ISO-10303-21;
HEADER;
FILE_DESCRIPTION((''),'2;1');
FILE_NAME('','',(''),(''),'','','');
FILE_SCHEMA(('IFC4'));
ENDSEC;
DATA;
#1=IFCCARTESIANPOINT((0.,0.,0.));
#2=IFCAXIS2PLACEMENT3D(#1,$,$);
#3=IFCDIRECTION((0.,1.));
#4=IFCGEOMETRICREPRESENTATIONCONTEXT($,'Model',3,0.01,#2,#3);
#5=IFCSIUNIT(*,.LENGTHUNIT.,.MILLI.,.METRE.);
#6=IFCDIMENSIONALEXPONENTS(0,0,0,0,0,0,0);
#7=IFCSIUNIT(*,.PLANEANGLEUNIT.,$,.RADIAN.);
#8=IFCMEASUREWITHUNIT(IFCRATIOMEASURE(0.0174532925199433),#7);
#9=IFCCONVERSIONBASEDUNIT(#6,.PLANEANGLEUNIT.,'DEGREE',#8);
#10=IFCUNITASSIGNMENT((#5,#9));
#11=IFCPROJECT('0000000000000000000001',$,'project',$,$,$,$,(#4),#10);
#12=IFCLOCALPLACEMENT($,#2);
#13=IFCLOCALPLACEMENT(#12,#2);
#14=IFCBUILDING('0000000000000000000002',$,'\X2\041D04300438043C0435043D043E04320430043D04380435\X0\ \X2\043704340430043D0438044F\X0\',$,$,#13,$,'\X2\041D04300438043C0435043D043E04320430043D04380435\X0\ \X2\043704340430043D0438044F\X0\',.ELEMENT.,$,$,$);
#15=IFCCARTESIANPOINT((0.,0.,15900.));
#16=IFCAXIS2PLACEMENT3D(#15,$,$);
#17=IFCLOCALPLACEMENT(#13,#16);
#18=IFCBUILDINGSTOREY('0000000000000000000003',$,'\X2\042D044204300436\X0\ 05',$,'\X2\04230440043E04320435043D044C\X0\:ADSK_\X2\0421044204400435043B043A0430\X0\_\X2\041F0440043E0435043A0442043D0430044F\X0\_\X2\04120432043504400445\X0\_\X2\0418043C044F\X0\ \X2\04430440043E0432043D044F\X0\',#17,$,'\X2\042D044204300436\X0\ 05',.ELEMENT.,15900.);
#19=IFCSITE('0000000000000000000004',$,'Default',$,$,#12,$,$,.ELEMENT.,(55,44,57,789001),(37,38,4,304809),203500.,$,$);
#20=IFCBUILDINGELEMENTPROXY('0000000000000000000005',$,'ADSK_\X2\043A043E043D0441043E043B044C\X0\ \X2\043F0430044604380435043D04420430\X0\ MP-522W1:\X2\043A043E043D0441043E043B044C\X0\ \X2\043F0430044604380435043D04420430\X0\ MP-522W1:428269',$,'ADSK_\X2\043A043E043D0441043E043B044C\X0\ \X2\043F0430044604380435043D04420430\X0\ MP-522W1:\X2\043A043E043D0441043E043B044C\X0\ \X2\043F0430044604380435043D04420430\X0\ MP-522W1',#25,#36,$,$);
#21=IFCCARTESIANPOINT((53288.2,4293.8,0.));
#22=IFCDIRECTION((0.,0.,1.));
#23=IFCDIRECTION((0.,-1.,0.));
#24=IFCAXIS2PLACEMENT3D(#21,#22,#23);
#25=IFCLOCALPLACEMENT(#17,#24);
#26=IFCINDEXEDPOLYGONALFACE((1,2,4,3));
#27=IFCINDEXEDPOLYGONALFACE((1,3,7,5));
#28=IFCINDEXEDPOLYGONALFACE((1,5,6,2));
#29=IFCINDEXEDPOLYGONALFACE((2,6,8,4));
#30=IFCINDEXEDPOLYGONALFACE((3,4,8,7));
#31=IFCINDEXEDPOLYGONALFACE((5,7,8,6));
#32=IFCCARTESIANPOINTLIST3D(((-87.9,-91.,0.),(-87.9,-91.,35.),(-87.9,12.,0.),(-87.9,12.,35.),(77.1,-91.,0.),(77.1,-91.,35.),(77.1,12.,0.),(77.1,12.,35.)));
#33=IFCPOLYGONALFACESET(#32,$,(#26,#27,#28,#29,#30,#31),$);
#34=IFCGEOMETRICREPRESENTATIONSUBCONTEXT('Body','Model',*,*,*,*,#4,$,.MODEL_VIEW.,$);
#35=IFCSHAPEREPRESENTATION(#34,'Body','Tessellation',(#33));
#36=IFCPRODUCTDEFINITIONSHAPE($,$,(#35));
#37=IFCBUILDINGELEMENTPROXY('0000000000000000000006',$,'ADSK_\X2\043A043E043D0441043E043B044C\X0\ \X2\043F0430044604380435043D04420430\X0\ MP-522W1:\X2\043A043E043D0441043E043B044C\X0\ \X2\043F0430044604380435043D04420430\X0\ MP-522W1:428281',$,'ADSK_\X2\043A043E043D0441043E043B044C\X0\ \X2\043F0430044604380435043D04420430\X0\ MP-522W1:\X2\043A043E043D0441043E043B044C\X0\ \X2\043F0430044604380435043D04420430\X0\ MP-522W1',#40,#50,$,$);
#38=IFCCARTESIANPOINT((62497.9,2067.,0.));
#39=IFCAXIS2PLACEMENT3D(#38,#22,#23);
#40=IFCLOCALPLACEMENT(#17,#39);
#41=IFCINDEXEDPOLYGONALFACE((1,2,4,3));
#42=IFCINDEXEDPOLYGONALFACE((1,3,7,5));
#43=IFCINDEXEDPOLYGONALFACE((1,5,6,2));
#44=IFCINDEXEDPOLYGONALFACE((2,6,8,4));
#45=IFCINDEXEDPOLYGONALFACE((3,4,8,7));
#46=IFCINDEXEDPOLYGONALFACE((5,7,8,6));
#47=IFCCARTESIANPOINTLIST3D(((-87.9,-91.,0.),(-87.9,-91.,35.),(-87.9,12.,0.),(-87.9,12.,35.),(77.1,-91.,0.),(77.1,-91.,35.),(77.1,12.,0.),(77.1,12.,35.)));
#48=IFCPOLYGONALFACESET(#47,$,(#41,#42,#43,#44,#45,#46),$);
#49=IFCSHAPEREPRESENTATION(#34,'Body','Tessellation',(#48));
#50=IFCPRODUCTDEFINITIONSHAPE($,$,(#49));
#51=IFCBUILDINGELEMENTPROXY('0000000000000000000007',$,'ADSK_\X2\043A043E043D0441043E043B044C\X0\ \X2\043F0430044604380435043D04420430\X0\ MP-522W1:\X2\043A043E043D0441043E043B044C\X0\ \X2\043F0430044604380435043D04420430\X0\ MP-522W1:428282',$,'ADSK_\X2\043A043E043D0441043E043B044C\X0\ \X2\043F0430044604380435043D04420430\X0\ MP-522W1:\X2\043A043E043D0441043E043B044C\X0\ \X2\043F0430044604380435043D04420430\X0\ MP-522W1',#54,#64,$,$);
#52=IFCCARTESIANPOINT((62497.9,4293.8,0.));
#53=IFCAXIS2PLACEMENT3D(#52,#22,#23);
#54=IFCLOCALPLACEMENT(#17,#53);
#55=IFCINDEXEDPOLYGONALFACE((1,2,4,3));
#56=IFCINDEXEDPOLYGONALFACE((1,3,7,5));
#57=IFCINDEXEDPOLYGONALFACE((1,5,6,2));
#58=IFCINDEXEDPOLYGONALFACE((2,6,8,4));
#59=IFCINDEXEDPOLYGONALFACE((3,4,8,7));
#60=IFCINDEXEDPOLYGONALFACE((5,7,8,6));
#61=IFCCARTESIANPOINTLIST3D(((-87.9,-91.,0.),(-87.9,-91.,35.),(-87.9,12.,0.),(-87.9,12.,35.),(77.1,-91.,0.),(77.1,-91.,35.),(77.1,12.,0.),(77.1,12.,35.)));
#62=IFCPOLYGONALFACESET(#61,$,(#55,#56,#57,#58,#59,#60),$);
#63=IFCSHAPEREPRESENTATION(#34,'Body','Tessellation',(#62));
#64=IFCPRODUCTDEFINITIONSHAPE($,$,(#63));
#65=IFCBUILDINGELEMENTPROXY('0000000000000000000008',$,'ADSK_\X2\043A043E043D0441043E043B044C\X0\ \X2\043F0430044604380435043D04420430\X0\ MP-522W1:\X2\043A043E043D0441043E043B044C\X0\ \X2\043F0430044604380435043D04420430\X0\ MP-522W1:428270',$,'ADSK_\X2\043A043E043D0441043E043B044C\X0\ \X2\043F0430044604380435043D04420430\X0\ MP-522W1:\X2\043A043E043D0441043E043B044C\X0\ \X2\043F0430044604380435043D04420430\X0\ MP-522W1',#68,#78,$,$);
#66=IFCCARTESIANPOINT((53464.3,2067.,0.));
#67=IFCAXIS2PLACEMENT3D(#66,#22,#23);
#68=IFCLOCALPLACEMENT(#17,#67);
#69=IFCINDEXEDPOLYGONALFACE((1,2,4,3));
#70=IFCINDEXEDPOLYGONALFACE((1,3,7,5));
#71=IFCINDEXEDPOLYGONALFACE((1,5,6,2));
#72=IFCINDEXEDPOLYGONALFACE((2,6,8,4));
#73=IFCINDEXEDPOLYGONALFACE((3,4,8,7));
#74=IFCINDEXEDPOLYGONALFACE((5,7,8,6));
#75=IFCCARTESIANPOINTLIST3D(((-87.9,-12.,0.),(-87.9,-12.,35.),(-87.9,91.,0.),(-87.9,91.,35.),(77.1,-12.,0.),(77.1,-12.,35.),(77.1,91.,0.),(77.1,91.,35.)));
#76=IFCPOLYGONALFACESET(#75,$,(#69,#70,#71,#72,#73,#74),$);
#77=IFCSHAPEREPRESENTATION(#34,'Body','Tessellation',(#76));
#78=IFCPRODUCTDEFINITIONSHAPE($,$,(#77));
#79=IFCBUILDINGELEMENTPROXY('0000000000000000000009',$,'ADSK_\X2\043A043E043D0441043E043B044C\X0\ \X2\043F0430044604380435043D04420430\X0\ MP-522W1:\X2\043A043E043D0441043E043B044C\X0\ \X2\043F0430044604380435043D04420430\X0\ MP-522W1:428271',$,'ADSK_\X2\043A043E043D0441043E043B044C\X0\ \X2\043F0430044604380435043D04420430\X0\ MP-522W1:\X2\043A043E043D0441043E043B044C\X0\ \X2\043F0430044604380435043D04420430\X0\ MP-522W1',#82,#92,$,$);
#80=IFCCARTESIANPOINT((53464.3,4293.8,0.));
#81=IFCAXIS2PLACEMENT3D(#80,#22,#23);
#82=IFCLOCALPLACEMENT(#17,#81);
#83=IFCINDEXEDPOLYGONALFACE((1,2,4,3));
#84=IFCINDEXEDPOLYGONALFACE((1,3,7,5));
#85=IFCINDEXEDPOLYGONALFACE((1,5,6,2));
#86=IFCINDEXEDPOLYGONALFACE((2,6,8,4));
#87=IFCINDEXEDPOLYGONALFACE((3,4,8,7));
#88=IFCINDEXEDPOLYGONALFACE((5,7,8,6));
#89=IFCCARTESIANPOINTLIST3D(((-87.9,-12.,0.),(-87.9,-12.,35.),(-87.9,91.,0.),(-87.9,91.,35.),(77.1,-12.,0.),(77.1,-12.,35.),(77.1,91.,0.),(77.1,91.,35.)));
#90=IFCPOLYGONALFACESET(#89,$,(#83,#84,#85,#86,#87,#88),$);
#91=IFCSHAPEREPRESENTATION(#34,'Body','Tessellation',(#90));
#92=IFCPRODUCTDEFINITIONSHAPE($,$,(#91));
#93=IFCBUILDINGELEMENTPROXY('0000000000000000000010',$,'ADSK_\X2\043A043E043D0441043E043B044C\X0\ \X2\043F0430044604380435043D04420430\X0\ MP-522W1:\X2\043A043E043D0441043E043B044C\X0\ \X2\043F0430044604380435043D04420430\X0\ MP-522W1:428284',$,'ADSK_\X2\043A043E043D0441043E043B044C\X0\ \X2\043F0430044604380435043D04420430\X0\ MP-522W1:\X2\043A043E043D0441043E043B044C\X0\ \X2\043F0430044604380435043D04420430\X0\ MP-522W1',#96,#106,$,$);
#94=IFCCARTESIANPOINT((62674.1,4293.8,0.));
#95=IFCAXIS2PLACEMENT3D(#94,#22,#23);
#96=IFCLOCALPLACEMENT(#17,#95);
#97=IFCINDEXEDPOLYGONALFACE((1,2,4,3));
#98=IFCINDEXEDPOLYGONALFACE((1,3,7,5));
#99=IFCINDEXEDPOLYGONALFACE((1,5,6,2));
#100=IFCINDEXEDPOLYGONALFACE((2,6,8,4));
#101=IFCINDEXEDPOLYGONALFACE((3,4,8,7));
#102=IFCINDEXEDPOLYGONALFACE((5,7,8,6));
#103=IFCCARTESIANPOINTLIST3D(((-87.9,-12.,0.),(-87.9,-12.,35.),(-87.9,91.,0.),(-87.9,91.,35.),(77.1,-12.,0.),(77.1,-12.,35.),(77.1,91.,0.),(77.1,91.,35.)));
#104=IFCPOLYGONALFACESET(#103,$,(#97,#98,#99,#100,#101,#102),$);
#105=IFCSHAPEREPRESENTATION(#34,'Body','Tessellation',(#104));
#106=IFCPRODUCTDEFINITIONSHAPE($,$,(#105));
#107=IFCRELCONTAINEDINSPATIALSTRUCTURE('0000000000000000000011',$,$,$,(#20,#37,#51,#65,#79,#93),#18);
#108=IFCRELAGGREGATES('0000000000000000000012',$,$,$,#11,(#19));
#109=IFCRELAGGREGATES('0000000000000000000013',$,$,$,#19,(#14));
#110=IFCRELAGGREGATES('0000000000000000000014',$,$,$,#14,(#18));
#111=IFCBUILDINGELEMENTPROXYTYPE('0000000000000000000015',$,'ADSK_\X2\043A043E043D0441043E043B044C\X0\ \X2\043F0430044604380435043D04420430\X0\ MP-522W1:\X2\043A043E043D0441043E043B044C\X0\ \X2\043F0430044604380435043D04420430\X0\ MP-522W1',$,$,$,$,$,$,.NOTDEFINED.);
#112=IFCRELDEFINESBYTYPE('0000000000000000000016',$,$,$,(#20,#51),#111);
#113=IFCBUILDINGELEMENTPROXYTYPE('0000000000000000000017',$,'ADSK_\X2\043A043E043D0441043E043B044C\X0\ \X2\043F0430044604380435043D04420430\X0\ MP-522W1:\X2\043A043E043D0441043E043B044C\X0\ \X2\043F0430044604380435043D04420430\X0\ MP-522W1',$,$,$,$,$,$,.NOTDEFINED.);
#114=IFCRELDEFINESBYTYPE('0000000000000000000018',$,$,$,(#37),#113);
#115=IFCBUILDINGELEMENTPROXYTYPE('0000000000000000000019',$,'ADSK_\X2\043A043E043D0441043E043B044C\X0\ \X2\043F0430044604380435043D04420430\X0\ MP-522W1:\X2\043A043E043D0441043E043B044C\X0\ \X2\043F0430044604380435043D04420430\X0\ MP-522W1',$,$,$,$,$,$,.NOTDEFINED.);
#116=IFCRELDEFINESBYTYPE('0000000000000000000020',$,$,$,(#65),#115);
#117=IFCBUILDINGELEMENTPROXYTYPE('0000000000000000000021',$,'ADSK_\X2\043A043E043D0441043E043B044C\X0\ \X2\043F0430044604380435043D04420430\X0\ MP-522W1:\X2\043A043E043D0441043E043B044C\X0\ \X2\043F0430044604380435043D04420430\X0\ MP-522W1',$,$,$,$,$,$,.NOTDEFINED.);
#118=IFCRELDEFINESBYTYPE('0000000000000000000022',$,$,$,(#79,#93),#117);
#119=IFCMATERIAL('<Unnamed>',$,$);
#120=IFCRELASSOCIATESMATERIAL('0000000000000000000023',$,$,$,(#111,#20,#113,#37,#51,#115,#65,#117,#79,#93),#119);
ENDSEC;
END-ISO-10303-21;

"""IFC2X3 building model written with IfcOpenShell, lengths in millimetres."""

from ifc_helpers import new_model, entity, si_unit, converted_unit, direction, frame, origin, origin_2d_with_axis, place, context, subcontext, project, spatial, rectangle, extrude, source, transform, mapped, material, type_object, type_shapes, element, save


model = new_model("IFC2X3")

# Units and contexts
model_context = context("Model", 3, precision=0.01, world=origin(), true_north=direction((0.0, 1.0)))
body_context = subcontext(model_context, "Body", "Model", "MODEL_VIEW")
ifc_project = project(units=[si_unit("LENGTHUNIT", "METRE", prefix="MILLI"), converted_unit("PLANEANGLEUNIT", "DEGREE", entity("IfcRatioMeasure", 0.0174532925199433), si_unit("PLANEANGLEUNIT", "RADIAN"), dimensions=[0, 0, 0, 0, 0, 0, 0])], contexts=[model_context])

# Site, building, storey
site_placement = place(None, origin())
site = spatial("IfcSite", under=ifc_project, at=site_placement, Name="Default", CompositionType="ELEMENT", RefLatitude=(55, 44, 57, 789001), RefLongitude=(37, 38, 4, 304809), RefElevation=203500.0)
building_placement = place(site_placement, origin())
building = spatial("IfcBuilding", under=site, at=building_placement, Name="Наименование здания", LongName="Наименование здания", CompositionType="ELEMENT")
storey_placement = place(building_placement, frame((0.0, 0.0, 15900.0)))
storey = spatial("IfcBuildingStorey", under=building, at=storey_placement, Name="Этаж 05", ObjectType="Уровень:ADSK_Стрелка_Проектная_Вверх_Имя уровня", LongName="Этаж 05", CompositionType="ELEMENT", Elevation=15900.0)

# Building element proxies
ifc_material = material(Name="<Unnamed>")
building_element_proxy_type_1 = type_object("IfcBuildingElementProxyType", Name="ADSK_консоль пациента MP-522W1:консоль пациента MP-522W1", PredefinedType="NOTDEFINED", material=ifc_material)
shared_shape_1 = source(origin(), body_context, "Body", "SweptSolid", [
    extrude(rectangle(XDim=165.0, YDim=103.0, at=origin_2d_with_axis()), frame((-5.4, -39.5, 0.0), z_axis=(0.0, 0.0, 1.0), x_axis=(-1.0, 0.0, 0.0)), (0.0, 0.0, 1.0), 35.0),
])
type_shapes(building_element_proxy_type_1, [shared_shape_1])
proxy_1_placement = place(storey_placement, frame((53288.2, 4293.8, 0.0), z_axis=(0.0, 0.0, 1.0), x_axis=(0.0, -1.0, 0.0)))
element("IfcBuildingElementProxy", 1, at=proxy_1_placement, inside=storey, type_object=building_element_proxy_type_1, material=ifc_material, Name="ADSK_консоль пациента MP-522W1:консоль пациента MP-522W1:428269", ObjectType="ADSK_консоль пациента MP-522W1:консоль пациента MP-522W1", context=body_context, shape_type="MappedRepresentation", body=[
    mapped(shared_shape_1, transform((0.0, 0.0, 0.0), scale=1.0)),
])
building_element_proxy_type_2 = type_object("IfcBuildingElementProxyType", Name="ADSK_консоль пациента MP-522W1:консоль пациента MP-522W1", PredefinedType="NOTDEFINED", material=ifc_material)
type_shapes(building_element_proxy_type_2, [shared_shape_1])
proxy_2_placement = place(storey_placement, frame((62497.9, 2067.0, 0.0), z_axis=(0.0, 0.0, 1.0), x_axis=(0.0, -1.0, 0.0)))
element("IfcBuildingElementProxy", 2, at=proxy_2_placement, inside=storey, type_object=building_element_proxy_type_2, material=ifc_material, Name="ADSK_консоль пациента MP-522W1:консоль пациента MP-522W1:428281", ObjectType="ADSK_консоль пациента MP-522W1:консоль пациента MP-522W1", context=body_context, shape_type="MappedRepresentation", body=[
    mapped(shared_shape_1, transform((0.0, 0.0, 0.0), scale=1.0)),
])
proxy_3_placement = place(storey_placement, frame((62497.9, 4293.8, 0.0), z_axis=(0.0, 0.0, 1.0), x_axis=(0.0, -1.0, 0.0)))
element("IfcBuildingElementProxy", 3, at=proxy_3_placement, inside=storey, type_object=building_element_proxy_type_1, material=ifc_material, Name="ADSK_консоль пациента MP-522W1:консоль пациента MP-522W1:428282", ObjectType="ADSK_консоль пациента MP-522W1:консоль пациента MP-522W1", context=body_context, shape_type="MappedRepresentation", body=[
    mapped(shared_shape_1, transform((0.0, 0.0, 0.0), scale=1.0)),
])
building_element_proxy_type_3 = type_object("IfcBuildingElementProxyType", Name="ADSK_консоль пациента MP-522W1:консоль пациента MP-522W1", PredefinedType="NOTDEFINED", material=ifc_material)
shared_shape_2 = source(origin(), body_context, "Body", "SweptSolid", [
    extrude(rectangle(XDim=103.0, YDim=165.0, at=origin_2d_with_axis()), frame((-5.4, 39.5, 0.0), z_axis=(0.0, 0.0, 1.0), x_axis=(0.0, 1.0, 0.0)), (0.0, 0.0, 1.0), 35.0),
])
type_shapes(building_element_proxy_type_3, [shared_shape_2])
proxy_4_placement = place(storey_placement, frame((53464.3, 2067.0, 0.0), z_axis=(0.0, 0.0, 1.0), x_axis=(0.0, -1.0, 0.0)))
element("IfcBuildingElementProxy", 4, at=proxy_4_placement, inside=storey, type_object=building_element_proxy_type_3, material=ifc_material, Name="ADSK_консоль пациента MP-522W1:консоль пациента MP-522W1:428270", ObjectType="ADSK_консоль пациента MP-522W1:консоль пациента MP-522W1", context=body_context, shape_type="MappedRepresentation", body=[
    mapped(shared_shape_2, transform((0.0, 0.0, 0.0), scale=1.0)),
])
building_element_proxy_type_4 = type_object("IfcBuildingElementProxyType", Name="ADSK_консоль пациента MP-522W1:консоль пациента MP-522W1", PredefinedType="NOTDEFINED", material=ifc_material)
type_shapes(building_element_proxy_type_4, [shared_shape_2])
for number, where, z_axis, x_axis, name in (
    (5, (53464.3, 4293.8, 0.0), (0.0, 0.0, 1.0), (0.0, -1.0, 0.0), "ADSK_консоль пациента MP-522W1:консоль пациента MP-522W1:428271"),
    (6, (62674.1, 4293.8, 0.0), (0.0, 0.0, 1.0), (0.0, -1.0, 0.0), "ADSK_консоль пациента MP-522W1:консоль пациента MP-522W1:428284"),
):
    element("IfcBuildingElementProxy", number, at=place(storey_placement, frame(where, z_axis=z_axis, x_axis=x_axis)), inside=storey, type_object=building_element_proxy_type_4, material=ifc_material, Name=name, ObjectType="ADSK_консоль пациента MP-522W1:консоль пациента MP-522W1", context=body_context, shape_type="MappedRepresentation", body=[
        mapped(shared_shape_2, transform((0.0, 0.0, 0.0), scale=1.0)),
    ])

save(model, "model.ifc")
